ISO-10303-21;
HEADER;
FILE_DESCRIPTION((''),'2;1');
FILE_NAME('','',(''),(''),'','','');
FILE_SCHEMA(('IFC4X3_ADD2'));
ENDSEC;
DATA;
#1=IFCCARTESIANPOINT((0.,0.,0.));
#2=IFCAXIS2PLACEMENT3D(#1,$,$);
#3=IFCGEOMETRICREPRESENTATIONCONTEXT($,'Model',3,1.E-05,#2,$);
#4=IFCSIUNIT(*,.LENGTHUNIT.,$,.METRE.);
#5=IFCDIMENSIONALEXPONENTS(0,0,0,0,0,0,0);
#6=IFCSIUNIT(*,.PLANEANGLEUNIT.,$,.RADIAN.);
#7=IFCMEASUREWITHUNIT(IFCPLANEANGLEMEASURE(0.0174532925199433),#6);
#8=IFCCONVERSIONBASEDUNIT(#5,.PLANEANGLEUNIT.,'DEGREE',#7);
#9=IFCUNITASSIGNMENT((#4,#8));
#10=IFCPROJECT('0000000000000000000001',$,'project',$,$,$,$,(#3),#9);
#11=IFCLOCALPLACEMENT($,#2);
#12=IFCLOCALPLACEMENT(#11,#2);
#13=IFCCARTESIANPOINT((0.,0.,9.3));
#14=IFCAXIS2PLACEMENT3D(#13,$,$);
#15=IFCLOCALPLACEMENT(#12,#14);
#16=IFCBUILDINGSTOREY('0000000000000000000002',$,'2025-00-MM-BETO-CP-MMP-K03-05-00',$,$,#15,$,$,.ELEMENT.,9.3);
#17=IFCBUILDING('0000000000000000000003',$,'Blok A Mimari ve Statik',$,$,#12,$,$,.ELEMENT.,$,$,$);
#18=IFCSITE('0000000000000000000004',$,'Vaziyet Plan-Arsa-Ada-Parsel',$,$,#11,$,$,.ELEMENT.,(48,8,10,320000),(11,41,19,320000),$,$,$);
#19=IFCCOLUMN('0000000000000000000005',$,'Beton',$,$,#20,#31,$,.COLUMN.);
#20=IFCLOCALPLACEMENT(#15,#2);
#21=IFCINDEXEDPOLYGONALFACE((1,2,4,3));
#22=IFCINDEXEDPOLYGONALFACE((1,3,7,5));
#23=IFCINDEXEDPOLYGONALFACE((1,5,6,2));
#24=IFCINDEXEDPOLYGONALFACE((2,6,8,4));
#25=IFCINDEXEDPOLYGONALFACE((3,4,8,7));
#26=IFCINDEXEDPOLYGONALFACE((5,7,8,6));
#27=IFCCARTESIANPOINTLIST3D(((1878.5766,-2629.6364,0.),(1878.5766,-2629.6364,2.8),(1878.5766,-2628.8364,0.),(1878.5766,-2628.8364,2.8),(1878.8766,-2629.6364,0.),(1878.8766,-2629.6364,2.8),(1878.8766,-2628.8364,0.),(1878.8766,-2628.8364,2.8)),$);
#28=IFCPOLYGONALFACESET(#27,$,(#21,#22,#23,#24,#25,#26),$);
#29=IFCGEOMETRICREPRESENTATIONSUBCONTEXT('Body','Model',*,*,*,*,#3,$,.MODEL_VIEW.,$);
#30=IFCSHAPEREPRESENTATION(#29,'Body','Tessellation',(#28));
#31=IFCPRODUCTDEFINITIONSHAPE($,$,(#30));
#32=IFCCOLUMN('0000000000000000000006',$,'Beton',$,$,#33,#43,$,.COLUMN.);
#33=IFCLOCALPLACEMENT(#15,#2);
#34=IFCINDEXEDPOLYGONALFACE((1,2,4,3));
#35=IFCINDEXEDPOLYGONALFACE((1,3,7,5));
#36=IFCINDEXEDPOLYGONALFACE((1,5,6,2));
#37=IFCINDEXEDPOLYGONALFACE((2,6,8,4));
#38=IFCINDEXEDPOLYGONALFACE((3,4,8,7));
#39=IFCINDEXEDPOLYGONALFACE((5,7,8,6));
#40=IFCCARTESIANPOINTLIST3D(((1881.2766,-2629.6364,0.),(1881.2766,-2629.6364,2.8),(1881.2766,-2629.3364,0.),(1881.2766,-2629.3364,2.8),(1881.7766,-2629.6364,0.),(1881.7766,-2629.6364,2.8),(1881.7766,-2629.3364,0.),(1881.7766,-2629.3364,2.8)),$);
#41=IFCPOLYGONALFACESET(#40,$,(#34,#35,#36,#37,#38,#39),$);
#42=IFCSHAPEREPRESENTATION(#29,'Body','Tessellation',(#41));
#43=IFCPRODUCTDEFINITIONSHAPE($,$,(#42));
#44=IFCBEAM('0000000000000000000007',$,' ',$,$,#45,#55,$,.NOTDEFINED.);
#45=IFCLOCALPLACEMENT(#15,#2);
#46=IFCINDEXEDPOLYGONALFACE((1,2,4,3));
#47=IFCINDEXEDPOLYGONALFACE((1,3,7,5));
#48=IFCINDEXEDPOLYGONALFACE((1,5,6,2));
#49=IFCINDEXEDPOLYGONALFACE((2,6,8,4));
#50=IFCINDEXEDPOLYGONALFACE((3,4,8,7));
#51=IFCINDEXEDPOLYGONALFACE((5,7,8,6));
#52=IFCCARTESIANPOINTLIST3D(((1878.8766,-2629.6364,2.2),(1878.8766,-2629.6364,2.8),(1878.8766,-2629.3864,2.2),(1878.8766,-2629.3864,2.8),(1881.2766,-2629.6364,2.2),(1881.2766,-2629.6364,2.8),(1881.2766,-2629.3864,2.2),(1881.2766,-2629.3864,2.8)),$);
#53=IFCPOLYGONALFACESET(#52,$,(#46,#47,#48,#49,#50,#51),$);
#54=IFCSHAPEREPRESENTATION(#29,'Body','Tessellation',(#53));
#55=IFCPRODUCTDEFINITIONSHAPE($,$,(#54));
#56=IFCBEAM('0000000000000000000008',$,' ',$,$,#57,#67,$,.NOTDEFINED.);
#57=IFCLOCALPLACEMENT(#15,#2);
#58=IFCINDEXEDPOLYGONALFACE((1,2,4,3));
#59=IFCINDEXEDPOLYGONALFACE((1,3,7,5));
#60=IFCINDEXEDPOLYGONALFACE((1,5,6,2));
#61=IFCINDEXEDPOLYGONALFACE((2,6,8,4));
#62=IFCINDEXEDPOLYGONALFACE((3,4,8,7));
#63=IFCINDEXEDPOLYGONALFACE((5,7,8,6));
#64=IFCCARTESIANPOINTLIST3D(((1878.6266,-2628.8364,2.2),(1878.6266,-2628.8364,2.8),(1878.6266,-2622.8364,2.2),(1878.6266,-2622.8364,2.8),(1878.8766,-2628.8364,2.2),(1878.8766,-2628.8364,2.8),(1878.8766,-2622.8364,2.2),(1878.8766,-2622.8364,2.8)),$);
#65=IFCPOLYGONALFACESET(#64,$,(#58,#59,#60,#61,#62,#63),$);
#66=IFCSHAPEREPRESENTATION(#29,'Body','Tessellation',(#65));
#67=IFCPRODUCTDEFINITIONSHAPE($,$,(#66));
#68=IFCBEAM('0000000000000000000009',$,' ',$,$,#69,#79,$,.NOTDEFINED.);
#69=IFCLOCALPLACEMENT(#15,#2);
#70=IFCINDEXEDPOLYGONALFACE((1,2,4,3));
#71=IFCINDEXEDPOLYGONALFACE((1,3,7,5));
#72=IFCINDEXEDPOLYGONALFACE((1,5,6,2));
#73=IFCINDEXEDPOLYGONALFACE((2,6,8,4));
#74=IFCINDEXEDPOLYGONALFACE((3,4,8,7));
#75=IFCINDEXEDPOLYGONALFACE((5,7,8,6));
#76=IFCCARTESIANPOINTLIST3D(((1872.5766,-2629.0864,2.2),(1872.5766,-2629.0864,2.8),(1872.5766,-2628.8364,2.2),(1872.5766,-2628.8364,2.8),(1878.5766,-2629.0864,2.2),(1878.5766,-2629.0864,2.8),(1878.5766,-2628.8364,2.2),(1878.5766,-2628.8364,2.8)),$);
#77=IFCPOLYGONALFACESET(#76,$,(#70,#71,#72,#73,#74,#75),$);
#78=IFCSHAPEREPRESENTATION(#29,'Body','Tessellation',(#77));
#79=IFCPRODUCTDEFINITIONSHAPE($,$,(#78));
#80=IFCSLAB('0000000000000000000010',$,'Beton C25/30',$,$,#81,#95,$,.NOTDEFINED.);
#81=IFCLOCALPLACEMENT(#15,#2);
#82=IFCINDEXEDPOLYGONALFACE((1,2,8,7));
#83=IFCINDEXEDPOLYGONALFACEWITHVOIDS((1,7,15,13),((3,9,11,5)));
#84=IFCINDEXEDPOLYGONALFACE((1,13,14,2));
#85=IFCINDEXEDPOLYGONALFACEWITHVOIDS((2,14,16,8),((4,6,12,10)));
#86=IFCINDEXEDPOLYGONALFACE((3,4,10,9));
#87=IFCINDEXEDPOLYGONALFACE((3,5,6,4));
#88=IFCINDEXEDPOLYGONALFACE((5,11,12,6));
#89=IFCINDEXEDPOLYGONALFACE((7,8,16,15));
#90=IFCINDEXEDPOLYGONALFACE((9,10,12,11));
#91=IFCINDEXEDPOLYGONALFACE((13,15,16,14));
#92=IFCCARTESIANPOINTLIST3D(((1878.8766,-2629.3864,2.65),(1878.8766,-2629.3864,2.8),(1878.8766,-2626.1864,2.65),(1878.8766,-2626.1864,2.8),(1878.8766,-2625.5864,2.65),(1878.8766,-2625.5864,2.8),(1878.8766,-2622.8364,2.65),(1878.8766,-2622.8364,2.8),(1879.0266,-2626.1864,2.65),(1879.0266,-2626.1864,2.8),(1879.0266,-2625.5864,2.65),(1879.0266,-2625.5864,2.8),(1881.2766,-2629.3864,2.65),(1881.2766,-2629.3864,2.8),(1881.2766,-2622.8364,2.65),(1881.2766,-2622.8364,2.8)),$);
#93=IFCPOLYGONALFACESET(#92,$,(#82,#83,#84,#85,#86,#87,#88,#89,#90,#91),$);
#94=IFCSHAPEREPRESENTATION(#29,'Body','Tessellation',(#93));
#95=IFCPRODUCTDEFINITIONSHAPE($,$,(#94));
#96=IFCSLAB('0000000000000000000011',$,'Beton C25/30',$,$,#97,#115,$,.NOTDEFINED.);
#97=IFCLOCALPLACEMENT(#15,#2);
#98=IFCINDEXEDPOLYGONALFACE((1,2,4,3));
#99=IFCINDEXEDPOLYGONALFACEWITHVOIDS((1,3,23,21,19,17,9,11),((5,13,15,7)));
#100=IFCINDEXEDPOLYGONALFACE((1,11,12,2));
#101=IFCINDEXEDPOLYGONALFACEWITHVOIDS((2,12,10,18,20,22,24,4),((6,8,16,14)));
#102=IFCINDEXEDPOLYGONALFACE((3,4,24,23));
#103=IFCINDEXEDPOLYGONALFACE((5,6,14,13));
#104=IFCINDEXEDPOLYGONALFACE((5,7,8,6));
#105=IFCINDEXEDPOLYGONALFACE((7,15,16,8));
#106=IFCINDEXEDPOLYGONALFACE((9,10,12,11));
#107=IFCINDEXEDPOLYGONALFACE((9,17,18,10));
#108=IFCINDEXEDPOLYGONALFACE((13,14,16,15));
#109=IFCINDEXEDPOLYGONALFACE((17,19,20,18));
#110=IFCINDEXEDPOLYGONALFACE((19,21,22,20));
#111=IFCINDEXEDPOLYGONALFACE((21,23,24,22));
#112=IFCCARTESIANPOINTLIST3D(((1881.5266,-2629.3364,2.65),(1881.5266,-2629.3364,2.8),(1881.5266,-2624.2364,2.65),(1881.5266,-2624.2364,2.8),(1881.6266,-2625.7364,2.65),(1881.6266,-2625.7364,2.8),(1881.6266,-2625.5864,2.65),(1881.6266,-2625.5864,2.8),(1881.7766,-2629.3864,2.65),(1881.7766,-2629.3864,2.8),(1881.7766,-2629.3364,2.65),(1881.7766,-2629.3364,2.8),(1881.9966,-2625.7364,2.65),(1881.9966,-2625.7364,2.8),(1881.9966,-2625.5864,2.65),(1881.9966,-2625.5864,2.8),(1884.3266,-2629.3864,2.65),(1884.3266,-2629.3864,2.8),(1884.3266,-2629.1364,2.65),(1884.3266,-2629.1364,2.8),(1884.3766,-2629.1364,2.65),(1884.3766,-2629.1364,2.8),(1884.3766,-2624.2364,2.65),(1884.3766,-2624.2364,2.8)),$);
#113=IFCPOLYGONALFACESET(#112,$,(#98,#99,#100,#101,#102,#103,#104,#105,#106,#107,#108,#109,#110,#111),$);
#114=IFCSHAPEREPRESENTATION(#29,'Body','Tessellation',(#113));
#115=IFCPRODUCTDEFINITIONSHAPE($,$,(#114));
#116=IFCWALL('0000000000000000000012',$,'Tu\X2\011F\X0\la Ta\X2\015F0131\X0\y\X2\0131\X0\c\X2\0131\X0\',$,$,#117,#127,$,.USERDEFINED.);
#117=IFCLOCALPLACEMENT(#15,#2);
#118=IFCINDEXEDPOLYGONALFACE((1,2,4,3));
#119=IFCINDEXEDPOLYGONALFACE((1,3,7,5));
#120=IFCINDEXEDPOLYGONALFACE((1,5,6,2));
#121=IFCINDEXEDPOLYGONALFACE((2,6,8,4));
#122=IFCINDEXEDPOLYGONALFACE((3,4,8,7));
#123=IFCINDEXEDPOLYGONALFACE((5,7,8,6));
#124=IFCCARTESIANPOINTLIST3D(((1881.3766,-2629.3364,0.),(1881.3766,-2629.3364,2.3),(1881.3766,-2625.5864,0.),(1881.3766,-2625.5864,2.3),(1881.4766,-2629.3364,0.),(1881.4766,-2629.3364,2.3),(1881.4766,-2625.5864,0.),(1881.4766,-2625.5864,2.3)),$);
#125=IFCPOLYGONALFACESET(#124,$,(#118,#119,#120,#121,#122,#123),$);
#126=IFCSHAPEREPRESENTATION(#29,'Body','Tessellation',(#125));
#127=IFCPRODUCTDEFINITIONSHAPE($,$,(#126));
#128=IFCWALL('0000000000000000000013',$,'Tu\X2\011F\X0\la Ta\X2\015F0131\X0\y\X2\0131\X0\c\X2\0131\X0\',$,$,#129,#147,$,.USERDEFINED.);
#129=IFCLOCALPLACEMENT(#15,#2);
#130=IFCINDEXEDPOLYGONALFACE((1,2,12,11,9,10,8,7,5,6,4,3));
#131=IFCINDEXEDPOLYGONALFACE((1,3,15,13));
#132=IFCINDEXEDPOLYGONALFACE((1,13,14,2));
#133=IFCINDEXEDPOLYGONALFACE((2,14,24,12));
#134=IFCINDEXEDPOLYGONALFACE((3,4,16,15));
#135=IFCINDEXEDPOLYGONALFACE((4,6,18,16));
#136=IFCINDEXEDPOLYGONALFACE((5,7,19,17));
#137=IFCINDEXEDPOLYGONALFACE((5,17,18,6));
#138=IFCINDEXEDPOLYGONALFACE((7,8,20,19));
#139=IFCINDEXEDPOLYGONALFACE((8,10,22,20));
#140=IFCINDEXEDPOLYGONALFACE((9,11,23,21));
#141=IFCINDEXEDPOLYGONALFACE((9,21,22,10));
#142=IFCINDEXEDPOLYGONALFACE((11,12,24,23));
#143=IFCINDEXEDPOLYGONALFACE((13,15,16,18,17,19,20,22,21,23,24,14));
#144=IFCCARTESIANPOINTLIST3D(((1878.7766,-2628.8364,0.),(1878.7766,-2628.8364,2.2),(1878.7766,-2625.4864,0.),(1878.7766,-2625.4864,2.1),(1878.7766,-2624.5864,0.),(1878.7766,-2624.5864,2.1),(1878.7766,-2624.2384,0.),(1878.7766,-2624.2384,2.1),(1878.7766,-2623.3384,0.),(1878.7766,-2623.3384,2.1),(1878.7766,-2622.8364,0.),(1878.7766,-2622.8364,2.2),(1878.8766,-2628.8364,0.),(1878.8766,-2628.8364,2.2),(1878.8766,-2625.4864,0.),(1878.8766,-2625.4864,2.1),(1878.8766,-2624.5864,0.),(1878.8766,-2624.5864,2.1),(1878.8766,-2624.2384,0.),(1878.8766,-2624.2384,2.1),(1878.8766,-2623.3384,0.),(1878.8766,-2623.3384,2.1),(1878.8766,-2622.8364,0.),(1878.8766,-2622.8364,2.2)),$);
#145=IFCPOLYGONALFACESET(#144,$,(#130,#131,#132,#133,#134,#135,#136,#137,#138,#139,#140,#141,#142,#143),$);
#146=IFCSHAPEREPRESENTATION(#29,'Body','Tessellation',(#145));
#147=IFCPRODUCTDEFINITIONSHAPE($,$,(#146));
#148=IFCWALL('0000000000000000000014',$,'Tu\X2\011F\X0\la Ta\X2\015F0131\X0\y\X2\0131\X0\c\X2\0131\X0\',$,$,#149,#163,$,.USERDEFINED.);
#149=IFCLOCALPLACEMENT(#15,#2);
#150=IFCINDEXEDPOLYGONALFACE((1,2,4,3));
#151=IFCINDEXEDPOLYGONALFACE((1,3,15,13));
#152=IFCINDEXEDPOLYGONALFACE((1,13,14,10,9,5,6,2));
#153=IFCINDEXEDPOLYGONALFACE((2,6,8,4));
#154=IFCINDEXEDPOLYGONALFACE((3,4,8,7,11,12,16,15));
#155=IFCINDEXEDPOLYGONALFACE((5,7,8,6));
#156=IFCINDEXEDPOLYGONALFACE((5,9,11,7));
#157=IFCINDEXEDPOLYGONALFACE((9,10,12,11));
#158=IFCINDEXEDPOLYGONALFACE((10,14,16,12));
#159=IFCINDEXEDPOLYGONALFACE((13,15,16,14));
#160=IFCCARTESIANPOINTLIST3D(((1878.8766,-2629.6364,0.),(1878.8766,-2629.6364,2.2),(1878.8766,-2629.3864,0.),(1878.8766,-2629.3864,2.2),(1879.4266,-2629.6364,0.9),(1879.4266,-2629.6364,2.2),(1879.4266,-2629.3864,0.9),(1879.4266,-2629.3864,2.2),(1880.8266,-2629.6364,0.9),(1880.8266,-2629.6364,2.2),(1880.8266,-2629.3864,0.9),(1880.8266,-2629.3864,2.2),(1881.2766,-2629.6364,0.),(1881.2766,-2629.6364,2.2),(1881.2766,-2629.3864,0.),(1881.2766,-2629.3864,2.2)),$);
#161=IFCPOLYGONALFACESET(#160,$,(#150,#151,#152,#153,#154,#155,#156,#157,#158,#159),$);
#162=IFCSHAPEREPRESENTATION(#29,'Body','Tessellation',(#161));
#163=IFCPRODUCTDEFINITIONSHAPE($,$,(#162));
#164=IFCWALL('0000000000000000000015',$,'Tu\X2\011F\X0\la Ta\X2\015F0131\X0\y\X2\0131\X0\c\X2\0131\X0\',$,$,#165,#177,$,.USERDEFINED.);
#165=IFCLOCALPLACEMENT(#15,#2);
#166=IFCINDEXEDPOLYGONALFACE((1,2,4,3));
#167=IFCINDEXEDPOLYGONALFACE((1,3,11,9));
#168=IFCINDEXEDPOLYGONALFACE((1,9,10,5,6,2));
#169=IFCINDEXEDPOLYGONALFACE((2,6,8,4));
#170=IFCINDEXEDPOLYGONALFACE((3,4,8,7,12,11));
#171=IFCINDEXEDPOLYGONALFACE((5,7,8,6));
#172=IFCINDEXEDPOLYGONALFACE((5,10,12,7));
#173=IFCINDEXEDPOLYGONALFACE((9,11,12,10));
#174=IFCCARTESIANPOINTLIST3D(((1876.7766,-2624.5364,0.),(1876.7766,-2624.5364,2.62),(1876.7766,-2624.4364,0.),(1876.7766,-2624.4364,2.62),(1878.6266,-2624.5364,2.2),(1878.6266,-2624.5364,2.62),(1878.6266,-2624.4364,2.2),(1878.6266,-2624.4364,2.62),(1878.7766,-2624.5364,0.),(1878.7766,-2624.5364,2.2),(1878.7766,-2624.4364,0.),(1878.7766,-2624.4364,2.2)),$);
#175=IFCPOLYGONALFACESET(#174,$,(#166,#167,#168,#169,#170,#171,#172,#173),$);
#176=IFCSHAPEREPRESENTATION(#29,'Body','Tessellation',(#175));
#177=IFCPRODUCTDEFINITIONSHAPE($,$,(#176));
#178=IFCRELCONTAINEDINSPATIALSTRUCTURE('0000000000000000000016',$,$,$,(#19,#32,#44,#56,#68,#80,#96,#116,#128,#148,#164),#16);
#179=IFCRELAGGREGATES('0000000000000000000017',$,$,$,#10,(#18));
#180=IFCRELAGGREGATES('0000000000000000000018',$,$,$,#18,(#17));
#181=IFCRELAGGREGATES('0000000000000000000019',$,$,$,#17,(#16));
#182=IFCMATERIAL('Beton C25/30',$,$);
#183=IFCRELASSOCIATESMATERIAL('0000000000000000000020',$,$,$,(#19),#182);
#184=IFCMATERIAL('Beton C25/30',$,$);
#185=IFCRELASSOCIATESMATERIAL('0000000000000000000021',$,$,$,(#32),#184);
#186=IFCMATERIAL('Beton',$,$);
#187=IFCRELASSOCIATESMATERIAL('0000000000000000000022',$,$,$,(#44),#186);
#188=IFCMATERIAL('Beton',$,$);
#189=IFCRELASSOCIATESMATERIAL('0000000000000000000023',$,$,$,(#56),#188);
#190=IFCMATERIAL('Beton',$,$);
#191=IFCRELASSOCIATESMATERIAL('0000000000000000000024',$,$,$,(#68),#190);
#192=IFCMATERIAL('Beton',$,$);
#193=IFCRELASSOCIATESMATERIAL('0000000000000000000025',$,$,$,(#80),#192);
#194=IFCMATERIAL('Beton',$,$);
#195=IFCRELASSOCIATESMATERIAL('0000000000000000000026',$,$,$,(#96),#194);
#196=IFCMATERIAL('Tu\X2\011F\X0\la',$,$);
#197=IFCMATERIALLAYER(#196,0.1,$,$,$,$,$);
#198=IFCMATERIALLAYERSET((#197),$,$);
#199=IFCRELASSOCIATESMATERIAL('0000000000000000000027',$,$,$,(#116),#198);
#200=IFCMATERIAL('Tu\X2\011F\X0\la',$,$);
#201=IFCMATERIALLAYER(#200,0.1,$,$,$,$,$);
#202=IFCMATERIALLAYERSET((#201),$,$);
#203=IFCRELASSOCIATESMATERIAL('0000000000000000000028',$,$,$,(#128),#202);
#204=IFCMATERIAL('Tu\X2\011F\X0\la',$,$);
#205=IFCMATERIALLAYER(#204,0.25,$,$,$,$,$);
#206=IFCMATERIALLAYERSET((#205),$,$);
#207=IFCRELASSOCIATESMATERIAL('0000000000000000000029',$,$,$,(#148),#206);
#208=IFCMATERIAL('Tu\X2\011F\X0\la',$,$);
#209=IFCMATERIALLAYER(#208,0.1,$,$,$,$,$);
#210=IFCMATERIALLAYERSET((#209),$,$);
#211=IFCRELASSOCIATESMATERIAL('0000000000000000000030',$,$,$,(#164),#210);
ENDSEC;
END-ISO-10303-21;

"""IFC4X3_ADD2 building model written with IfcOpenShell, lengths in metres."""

from ifc_helpers import new_model, entity, si_unit, converted_unit, frame, frame_2d, origin, origin_with_axes, place, context, subcontext, project, spatial, polyline, rectangle, outline, extrude, clip, bounded_halfspace, material, layer, layer_set, layer_usage, element, save


model = new_model("IFC4X3_ADD2")

# Units and contexts
model_context = context("Model", 3, precision=1e-05, world=origin())
body_context = subcontext(model_context, "Body", "Model", "MODEL_VIEW")
ifc_project = project(units=[si_unit("LENGTHUNIT", "METRE"), converted_unit("PLANEANGLEUNIT", "DEGREE", entity("IfcPlaneAngleMeasure", 0.0174532925199433), si_unit("PLANEANGLEUNIT", "RADIAN"), dimensions=[0, 0, 0, 0, 0, 0, 0])], contexts=[model_context])

# Site, building, storey
site_placement = place(None, origin())
site = spatial("IfcSite", under=ifc_project, at=site_placement, Name="Vaziyet Plan-Arsa-Ada-Parsel", CompositionType="ELEMENT", RefLatitude=(48, 8, 10, 320000), RefLongitude=(11, 41, 19, 320000))
building_placement = place(site_placement, origin())
building = spatial("IfcBuilding", under=site, at=building_placement, Name="Blok A Mimari ve Statik", CompositionType="ELEMENT")
storey_placement = place(building_placement, frame((0.0, 0.0, 9.3)))
storey = spatial("IfcBuildingStorey", under=building, at=storey_placement, Name="2025-00-MM-BETO-CP-MMP-K03-05-00", CompositionType="ELEMENT", Elevation=9.3)

# Columns
ifc_material_1 = material(Name="Beton C25/30")
column_1_placement = place(storey_placement, frame((1878.5766, -2629.6364, 0.0)))
element("IfcColumn", 1, at=column_1_placement, inside=storey, material=ifc_material_1, Name="Beton", PredefinedType="COLUMN", context=body_context, shape_type="SweptSolid", body=[
    extrude(outline(polyline([(0.0, 0.0), (0.3, 0.0), (0.3, 0.8), (0.0, 0.8), (0.0, 0.0)])), origin_with_axes(), (0.0, 0.0, 1.0), 2.8),
])
ifc_material_2 = material(Name="Beton C25/30")
column_2_placement = place(storey_placement, frame((1881.2766, -2629.6364, 0.0)))
element("IfcColumn", 2, at=column_2_placement, inside=storey, material=ifc_material_2, Name="Beton", PredefinedType="COLUMN", context=body_context, shape_type="SweptSolid", body=[
    extrude(outline(polyline([(0.0, 0.3), (0.0, 0.0), (0.5, 0.0), (0.5, 0.3), (0.0, 0.3)])), origin_with_axes(), (0.0, 0.0, 1.0), 2.8),
])

# Beams
ifc_material_3 = material(Name="Beton")
beam_1_placement = place(storey_placement, frame((1878.8766, -2629.6364, 2.2)))
element("IfcBeam", 3, at=beam_1_placement, inside=storey, material=ifc_material_3, Name=" ", PredefinedType="NOTDEFINED", context=body_context, shape_type="SweptSolid", body=[
    extrude(rectangle(XDim=0.25, YDim=0.6, at=frame_2d((0.125, 0.3), x_axis=(1.0, 0.0))), frame((0.0, 0.0, 0.0), z_axis=(1.0, 0.0, 0.0), x_axis=(0.0, 1.0, 0.0)), (0.0, 0.0, 1.0), 2.4),
])
ifc_material_4 = material(Name="Beton")
beam_2_placement = place(storey_placement, frame((1878.8766, -2628.8364, 2.2), z_axis=(0.0, 0.0, 1.0), x_axis=(0.0, 1.0, 0.0)))
element("IfcBeam", 4, at=beam_2_placement, inside=storey, material=ifc_material_4, Name=" ", PredefinedType="NOTDEFINED", context=body_context, shape_type="SweptSolid", body=[
    extrude(rectangle(XDim=0.25, YDim=0.6, at=frame_2d((0.125, 0.3), x_axis=(1.0, 0.0))), frame((0.0, 0.0, 0.0), z_axis=(1.0, 0.0, 0.0), x_axis=(0.0, 1.0, 0.0)), (0.0, 0.0, 1.0), 6.0),
])
ifc_material_5 = material(Name="Beton")
beam_3_placement = place(storey_placement, frame((1878.5766, -2628.8364, 2.2), z_axis=(0.0, 0.0, 1.0), x_axis=(-1.0, 0.0, 0.0)))
element("IfcBeam", 5, at=beam_3_placement, inside=storey, material=ifc_material_5, Name=" ", PredefinedType="NOTDEFINED", context=body_context, shape_type="SweptSolid", body=[
    extrude(rectangle(XDim=0.25, YDim=0.6, at=frame_2d((0.125, 0.3), x_axis=(1.0, 0.0))), frame((0.0, 0.0, 0.0), z_axis=(1.0, 0.0, 0.0), x_axis=(0.0, 1.0, 0.0)), (0.0, 0.0, 1.0), 6.0),
])

# Slabs
ifc_material_6 = material(Name="Beton")
slab_1_placement = place(storey_placement, frame((1878.8766, -2629.3864, 2.65)))
element("IfcSlab", 6, at=slab_1_placement, inside=storey, material=ifc_material_6, Name="Beton C25/30", PredefinedType="NOTDEFINED", context=body_context, shape_type="SweptSolid", body=[
    extrude(outline(polyline([(2.4, 6.55), (0.0, 6.55), (0.0, 0.0), (2.4, 0.0), (2.4, 6.55)]), holes=[polyline([(0.0, 3.8), (0.15, 3.8), (0.15, 3.2), (0.0, 3.2), (0.0, 3.8)])]), origin_with_axes(), (0.0, 0.0, 1.0), 0.15),
])
ifc_material_7 = material(Name="Beton")
slab_2_placement = place(storey_placement, frame((1881.5266, -2629.3864, 2.65)))
element("IfcSlab", 7, at=slab_2_placement, inside=storey, material=ifc_material_7, Name="Beton C25/30", PredefinedType="NOTDEFINED", context=body_context, shape_type="SweptSolid", body=[
    extrude(outline(polyline([(0.0, 5.15), (0.0, 0.05), (0.25, 0.05), (0.25, 0.0), (2.8, 0.0), (2.8, 0.25), (2.85, 0.25), (2.85, 5.15), (0.0, 5.15)]), holes=[polyline([(0.1, 3.8), (0.47, 3.8), (0.47, 3.65), (0.1, 3.65), (0.1, 3.8)])]), origin_with_axes(), (0.0, 0.0, 1.0), 0.15),
])

# Wall
ifc_material_8 = material(Name="Tuğla")
ifc_layer_1 = layer(ifc_material_8, 0.1)
ifc_layer_set_1 = layer_set([ifc_layer_1])
ifc_layer_usage_1 = layer_usage(ifc_layer_set_1, "AXIS2", "POSITIVE", 0.0)
wall_1_placement = place(storey_placement, frame((1881.4766, -2629.3364, 0.0), z_axis=(0.0, 0.0, 1.0), x_axis=(0.0, 1.0, 0.0)))
element("IfcWall", 8, at=wall_1_placement, inside=storey, material=ifc_layer_usage_1, Name="Tuğla Taşıyıcı", PredefinedType="USERDEFINED", context=body_context, shape_type="SweptSolid", body=[
    extrude(rectangle(XDim=3.75, YDim=0.1, at=frame_2d((1.875, 0.05), x_axis=(1.0, 0.0))), origin_with_axes(), (0.0, 0.0, 1.0), 2.3),
])

# Wall, openings
ifc_material_9 = material(Name="Tuğla")
ifc_layer_2 = layer(ifc_material_9, 0.1)
ifc_layer_set_2 = layer_set([ifc_layer_2])
ifc_layer_usage_2 = layer_usage(ifc_layer_set_2, "AXIS2", "POSITIVE", 0.0)
wall_2_placement = place(storey_placement, frame((1878.8766, -2628.8364, 0.0), z_axis=(0.0, 0.0, 1.0), x_axis=(0.0, 1.0, 0.0)))
wall_2 = element("IfcWall", 9, at=wall_2_placement, inside=storey, material=ifc_layer_usage_2, Name="Tuğla Taşıyıcı", PredefinedType="USERDEFINED", context=body_context, shape_type="SweptSolid", body=[
    extrude(rectangle(XDim=6.0, YDim=0.1, at=frame_2d((3.0, 0.05), x_axis=(1.0, 0.0))), origin_with_axes(), (0.0, 0.0, 1.0), 2.2),
])
opening_1_placement = place(wall_2_placement, frame((5.498, 0.1, 0.0), z_axis=(0.0, -1.0, 0.0), x_axis=(0.0, 0.0, 1.0)))
element("IfcOpeningElement", 10, at=opening_1_placement, cuts=wall_2, PredefinedType="OPENING", context=body_context, shape_type="SweptSolid", body=[
    extrude(outline(polyline([(2.1, 0.9), (2.1, 0.0), (0.0, 0.0), (0.0, 0.9), (2.1, 0.9)])), origin_with_axes(), (0.0, 0.0, 1.0), 0.1),
])
opening_2_placement = place(wall_2_placement, frame((4.25, 0.1, 0.0), z_axis=(0.0, -1.0, 0.0), x_axis=(0.0, 0.0, 1.0)))
element("IfcOpeningElement", 11, at=opening_2_placement, cuts=wall_2, PredefinedType="OPENING", context=body_context, shape_type="SweptSolid", body=[
    extrude(outline(polyline([(2.1, 0.9), (2.1, 0.0), (0.0, 0.0), (0.0, 0.9), (2.1, 0.9)])), origin_with_axes(), (0.0, 0.0, 1.0), 0.1),
])

# Wall, opening
ifc_material_10 = material(Name="Tuğla")
ifc_layer_3 = layer(ifc_material_10, 0.25)
ifc_layer_set_3 = layer_set([ifc_layer_3])
ifc_layer_usage_3 = layer_usage(ifc_layer_set_3, "AXIS2", "POSITIVE", 0.0)
wall_3_placement = place(storey_placement, frame((1878.8766, -2629.6364, 0.0)))
wall_3 = element("IfcWall", 12, at=wall_3_placement, inside=storey, material=ifc_layer_usage_3, Name="Tuğla Taşıyıcı", PredefinedType="USERDEFINED", context=body_context, shape_type="SweptSolid", body=[
    extrude(rectangle(XDim=2.4, YDim=0.25, at=frame_2d((1.2, 0.125), x_axis=(1.0, 0.0))), origin_with_axes(), (0.0, 0.0, 1.0), 2.2),
])
opening_3_placement = place(wall_3_placement, frame((0.55, 0.0, 0.9), z_axis=(0.0, 1.0, 0.0), x_axis=(0.0, 0.0, 1.0)))
element("IfcOpeningElement", 13, at=opening_3_placement, cuts=wall_3, PredefinedType="OPENING", context=body_context, shape_type="SweptSolid", body=[
    extrude(outline(polyline([(1.35, 1.4), (1.35, 0.0), (0.0, 0.0), (0.0, 1.4), (1.35, 1.4)])), origin_with_axes(), (0.0, 0.0, 1.0), 0.25),
])

# Wall
ifc_material_11 = material(Name="Tuğla")
ifc_layer_4 = layer(ifc_material_11, 0.1)
ifc_layer_set_4 = layer_set([ifc_layer_4])
ifc_layer_usage_4 = layer_usage(ifc_layer_set_4, "AXIS2", "POSITIVE", 0.0)
wall_4_placement = place(storey_placement, frame((1876.7766, -2624.5364, 0.0)))
element("IfcWall", 14, at=wall_4_placement, inside=storey, material=ifc_layer_usage_4, Name="Tuğla Taşıyıcı", PredefinedType="USERDEFINED", context=body_context, shape_type="Clipping", body=[
    clip(extrude(rectangle(XDim=2.0, YDim=0.1, at=frame_2d((1.0, 0.05), x_axis=(1.0, 0.0))), origin_with_axes(), (0.0, 0.0, 1.0), 2.62), bounded_halfspace(frame((1.925, 0.05, 2.2), z_axis=(0.0, 0.0, -1.0), x_axis=(0.0, -1.0, 0.0)), True, origin_with_axes(), polyline([(1.85, 0.1), (1.85, 0.0), (2.0, 0.0), (2.0, 0.1), (1.85, 0.1)]))),
])

save(model, "model.ifc")
